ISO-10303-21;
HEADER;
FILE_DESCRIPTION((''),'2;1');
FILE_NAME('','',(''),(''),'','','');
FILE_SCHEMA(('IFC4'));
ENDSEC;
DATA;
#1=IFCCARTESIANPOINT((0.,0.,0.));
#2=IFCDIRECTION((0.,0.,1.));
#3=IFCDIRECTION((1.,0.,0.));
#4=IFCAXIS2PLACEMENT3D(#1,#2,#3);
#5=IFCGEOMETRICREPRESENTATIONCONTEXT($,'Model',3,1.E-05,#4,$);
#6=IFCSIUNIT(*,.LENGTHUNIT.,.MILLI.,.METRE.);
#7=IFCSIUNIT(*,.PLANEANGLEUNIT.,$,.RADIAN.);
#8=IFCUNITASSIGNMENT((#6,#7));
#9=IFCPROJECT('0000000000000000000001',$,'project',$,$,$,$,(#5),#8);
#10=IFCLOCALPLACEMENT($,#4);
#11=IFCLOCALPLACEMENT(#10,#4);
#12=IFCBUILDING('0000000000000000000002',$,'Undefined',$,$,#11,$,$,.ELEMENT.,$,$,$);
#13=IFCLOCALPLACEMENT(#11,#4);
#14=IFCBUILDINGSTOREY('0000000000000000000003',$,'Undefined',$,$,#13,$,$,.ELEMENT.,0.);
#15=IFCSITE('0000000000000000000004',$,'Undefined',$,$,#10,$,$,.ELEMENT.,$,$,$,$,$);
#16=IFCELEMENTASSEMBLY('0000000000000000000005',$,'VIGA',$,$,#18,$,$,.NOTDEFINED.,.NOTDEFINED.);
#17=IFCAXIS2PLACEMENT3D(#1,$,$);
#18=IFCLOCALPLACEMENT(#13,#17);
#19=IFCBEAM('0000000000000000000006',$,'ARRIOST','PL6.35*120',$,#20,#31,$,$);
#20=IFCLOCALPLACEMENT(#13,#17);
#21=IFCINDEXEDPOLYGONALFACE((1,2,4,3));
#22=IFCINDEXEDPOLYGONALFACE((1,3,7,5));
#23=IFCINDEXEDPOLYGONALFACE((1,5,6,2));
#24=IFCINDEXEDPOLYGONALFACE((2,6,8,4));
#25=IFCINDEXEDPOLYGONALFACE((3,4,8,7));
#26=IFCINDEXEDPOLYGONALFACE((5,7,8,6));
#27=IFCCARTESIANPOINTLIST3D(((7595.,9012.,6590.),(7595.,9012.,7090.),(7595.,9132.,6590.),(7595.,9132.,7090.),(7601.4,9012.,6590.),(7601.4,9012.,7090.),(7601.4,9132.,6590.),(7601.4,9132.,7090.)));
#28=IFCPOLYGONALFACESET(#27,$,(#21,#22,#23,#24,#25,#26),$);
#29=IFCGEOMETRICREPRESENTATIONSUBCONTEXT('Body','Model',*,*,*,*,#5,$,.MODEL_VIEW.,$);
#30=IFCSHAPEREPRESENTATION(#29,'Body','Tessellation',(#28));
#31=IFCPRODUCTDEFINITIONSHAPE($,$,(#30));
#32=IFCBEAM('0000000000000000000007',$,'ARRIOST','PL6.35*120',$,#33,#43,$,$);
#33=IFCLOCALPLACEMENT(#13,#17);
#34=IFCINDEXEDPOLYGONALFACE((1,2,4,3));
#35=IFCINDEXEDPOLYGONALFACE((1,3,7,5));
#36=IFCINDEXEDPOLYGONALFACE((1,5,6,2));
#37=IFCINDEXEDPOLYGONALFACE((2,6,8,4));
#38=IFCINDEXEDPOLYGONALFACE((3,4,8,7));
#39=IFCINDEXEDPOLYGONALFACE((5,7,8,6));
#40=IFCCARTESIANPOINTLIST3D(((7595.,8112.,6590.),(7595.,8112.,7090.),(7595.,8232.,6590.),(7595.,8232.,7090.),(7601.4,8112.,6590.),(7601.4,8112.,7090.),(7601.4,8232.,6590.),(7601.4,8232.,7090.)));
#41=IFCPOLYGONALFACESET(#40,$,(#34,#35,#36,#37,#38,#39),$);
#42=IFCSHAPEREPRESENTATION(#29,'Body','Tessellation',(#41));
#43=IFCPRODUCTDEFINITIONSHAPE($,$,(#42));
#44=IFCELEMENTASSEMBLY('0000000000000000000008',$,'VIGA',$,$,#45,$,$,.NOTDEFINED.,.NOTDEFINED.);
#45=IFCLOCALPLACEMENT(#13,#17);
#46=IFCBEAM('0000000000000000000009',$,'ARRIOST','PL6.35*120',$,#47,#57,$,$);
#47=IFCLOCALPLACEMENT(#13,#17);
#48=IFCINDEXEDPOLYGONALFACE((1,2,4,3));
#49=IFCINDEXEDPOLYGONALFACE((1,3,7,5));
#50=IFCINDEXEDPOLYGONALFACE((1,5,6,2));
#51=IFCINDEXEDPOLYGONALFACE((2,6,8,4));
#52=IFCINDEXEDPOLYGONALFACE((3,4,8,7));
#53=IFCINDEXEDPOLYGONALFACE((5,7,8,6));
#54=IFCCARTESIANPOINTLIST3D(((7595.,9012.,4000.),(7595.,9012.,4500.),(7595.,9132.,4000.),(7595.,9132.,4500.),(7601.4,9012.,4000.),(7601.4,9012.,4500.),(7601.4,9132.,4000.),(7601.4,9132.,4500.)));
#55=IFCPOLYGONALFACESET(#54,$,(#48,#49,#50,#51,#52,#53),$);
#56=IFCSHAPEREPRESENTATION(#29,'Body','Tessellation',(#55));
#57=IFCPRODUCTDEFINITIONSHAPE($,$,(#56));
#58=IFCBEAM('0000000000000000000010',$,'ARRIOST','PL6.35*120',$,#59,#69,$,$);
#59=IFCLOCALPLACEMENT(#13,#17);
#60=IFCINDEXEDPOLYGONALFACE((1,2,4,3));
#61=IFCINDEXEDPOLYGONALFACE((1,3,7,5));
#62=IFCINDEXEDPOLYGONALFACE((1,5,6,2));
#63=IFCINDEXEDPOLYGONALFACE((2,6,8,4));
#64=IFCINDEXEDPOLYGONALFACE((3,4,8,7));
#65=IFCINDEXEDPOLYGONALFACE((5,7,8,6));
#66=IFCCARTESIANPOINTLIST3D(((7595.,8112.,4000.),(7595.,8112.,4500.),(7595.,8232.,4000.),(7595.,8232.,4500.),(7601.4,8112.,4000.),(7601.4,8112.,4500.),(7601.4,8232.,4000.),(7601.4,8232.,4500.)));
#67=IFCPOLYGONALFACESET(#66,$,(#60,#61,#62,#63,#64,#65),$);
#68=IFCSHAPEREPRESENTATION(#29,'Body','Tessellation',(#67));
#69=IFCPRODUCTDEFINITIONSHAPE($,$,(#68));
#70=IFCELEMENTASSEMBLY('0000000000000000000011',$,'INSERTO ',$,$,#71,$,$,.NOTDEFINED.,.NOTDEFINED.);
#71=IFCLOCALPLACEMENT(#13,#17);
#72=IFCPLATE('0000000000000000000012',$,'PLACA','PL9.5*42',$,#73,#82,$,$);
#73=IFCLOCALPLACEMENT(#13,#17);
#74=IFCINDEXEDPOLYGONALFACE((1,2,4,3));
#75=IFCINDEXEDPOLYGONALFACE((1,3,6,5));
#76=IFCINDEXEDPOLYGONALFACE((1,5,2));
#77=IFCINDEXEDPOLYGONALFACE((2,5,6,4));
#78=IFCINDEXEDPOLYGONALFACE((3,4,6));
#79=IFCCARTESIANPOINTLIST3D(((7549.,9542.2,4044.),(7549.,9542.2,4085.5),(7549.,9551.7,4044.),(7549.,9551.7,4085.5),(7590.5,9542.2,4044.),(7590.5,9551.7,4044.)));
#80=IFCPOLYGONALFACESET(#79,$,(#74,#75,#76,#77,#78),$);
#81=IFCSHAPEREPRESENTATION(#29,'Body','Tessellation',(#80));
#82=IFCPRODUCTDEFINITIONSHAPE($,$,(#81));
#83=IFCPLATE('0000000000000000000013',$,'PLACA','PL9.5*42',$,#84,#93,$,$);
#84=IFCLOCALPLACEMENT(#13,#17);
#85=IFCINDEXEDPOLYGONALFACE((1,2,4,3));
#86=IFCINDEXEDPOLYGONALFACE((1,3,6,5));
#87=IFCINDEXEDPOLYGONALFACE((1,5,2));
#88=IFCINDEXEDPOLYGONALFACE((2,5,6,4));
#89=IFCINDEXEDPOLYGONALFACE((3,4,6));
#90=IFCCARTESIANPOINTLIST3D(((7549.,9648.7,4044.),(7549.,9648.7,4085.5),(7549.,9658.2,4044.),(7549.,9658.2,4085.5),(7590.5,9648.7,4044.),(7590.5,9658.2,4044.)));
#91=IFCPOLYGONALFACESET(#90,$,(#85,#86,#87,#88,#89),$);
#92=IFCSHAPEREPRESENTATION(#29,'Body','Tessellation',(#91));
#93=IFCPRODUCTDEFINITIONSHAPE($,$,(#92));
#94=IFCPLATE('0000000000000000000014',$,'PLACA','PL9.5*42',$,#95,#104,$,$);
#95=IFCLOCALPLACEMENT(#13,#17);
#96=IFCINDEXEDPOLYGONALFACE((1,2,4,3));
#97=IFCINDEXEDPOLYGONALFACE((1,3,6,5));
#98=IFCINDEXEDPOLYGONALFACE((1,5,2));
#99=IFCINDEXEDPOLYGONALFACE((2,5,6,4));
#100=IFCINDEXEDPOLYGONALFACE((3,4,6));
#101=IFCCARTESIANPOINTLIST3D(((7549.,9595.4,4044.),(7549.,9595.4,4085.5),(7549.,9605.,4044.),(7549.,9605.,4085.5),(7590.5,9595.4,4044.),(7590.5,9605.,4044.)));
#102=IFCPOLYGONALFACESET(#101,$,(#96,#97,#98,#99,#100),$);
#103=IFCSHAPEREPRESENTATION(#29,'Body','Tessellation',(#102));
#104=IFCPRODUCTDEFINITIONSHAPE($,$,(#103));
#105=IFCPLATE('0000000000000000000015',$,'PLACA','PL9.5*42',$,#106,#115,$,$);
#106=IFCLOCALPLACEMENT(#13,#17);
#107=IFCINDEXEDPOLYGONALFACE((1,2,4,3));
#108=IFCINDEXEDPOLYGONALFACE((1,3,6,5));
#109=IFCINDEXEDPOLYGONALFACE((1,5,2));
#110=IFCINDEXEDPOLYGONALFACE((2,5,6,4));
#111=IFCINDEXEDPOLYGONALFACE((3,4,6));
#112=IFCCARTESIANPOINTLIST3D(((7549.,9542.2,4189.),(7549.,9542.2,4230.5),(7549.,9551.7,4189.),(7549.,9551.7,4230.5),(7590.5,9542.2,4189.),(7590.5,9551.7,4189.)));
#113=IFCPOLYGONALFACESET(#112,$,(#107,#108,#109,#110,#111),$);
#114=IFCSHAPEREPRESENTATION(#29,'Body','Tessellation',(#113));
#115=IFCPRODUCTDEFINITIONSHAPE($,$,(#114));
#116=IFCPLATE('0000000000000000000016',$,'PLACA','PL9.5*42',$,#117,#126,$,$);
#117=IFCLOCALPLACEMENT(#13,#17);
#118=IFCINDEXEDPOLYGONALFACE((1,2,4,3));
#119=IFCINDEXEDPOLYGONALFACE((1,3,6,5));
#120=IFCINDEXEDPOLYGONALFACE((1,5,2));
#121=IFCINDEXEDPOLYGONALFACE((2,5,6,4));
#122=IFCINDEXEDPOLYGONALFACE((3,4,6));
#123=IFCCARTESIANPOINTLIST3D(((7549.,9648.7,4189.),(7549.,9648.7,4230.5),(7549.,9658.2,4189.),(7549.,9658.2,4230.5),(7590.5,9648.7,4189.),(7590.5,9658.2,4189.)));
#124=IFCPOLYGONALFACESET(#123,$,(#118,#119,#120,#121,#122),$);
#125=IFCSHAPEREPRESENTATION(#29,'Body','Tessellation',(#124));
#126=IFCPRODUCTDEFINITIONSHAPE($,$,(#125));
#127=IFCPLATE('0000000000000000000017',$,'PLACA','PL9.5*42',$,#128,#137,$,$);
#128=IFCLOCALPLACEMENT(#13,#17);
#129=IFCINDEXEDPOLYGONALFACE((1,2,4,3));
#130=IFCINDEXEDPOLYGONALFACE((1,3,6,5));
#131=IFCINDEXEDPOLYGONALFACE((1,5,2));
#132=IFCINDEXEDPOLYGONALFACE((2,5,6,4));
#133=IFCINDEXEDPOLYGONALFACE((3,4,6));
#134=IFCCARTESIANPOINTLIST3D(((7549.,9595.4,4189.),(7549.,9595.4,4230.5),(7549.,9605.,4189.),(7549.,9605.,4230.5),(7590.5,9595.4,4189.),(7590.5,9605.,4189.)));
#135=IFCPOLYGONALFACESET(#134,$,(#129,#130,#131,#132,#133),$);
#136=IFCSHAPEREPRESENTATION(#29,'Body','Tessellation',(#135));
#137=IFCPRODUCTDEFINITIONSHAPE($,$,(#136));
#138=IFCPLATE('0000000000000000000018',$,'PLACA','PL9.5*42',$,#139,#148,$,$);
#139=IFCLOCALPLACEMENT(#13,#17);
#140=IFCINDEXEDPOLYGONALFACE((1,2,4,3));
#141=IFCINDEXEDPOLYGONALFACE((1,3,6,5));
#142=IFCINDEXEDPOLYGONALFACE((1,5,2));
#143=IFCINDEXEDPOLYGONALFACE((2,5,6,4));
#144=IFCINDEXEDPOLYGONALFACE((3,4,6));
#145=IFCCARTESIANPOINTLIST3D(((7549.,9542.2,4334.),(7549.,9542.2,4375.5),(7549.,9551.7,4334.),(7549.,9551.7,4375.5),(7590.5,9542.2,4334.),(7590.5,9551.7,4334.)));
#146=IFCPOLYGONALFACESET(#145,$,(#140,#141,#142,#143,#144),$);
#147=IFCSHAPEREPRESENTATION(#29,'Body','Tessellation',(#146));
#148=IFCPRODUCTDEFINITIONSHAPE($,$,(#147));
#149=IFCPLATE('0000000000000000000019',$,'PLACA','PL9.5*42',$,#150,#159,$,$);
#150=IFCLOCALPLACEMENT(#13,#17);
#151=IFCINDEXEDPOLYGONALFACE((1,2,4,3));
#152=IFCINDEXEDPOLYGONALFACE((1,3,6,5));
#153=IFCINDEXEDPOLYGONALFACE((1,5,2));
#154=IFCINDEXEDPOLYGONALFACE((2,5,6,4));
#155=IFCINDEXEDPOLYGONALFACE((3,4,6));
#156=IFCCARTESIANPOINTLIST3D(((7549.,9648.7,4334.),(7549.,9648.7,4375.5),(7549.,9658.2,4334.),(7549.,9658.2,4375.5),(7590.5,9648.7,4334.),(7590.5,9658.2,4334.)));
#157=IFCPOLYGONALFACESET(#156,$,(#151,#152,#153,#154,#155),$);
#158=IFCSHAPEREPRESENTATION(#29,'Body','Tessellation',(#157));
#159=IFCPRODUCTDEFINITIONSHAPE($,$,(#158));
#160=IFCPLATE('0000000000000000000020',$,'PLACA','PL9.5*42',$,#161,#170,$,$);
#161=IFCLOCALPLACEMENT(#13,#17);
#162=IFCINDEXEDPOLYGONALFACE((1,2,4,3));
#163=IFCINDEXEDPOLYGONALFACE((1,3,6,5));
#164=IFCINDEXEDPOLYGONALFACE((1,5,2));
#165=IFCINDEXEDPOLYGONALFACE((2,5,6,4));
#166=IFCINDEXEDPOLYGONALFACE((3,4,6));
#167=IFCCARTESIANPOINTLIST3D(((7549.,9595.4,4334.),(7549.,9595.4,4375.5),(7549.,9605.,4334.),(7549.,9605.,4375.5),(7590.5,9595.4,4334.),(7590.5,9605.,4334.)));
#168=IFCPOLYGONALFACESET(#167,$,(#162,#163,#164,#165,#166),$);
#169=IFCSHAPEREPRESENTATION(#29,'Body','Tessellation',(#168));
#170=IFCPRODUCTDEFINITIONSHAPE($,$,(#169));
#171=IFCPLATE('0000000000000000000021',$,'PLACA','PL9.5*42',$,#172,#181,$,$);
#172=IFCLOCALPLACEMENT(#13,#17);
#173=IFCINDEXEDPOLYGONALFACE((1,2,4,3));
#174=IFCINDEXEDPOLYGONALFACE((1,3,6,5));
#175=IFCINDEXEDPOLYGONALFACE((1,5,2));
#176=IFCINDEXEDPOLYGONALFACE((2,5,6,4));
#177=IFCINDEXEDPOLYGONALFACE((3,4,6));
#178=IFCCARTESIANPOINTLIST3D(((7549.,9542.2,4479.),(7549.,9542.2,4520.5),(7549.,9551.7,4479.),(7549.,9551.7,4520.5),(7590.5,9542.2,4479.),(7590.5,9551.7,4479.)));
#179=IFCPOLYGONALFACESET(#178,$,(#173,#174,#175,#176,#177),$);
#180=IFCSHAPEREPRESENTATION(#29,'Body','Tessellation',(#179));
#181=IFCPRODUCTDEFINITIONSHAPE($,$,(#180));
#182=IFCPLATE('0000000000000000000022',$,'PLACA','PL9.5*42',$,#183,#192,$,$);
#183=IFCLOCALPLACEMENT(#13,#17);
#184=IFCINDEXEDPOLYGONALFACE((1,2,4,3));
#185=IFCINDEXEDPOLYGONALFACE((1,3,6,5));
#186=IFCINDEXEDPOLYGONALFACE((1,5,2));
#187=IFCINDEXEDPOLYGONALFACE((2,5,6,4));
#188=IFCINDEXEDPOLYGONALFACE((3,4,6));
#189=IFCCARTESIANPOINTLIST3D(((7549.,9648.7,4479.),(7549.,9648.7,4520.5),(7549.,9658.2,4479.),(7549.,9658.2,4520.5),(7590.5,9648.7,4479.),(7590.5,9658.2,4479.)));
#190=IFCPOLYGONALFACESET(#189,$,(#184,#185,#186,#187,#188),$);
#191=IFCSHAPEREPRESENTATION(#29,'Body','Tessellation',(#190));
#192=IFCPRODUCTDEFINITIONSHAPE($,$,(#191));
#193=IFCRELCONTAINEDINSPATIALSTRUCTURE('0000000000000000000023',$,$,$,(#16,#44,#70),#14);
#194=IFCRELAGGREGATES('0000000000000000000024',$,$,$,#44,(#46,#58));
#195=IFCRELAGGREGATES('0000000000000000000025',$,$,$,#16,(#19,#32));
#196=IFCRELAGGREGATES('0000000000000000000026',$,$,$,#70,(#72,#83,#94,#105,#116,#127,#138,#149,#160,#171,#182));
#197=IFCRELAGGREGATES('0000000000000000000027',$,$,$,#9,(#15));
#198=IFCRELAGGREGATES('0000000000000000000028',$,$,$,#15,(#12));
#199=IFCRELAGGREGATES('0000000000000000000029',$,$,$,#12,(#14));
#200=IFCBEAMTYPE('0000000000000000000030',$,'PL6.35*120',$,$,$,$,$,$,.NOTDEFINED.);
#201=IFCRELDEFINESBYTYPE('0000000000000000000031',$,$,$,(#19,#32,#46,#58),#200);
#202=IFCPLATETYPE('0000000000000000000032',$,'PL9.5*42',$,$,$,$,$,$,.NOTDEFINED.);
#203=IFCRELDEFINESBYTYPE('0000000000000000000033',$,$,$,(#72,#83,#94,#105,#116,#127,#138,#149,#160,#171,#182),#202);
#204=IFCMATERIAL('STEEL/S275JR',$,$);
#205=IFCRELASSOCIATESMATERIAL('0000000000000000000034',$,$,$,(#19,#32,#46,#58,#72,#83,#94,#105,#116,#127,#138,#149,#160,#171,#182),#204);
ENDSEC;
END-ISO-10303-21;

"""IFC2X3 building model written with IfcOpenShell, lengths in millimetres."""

from ifc_helpers import new_model, si_unit, frame, origin_with_axes, origin_2d_with_axis, place, context, subcontext, project, spatial, polyline, rectangle, outline, extrude, material, type_object, element, aggregate, save


model = new_model("IFC2X3")

# Units and contexts
model_context = context("Model", 3, precision=1e-05, world=origin_with_axes())
body_context = subcontext(model_context, "Body", "Model", "MODEL_VIEW")
ifc_project = project(units=[si_unit("LENGTHUNIT", "METRE", prefix="MILLI"), si_unit("PLANEANGLEUNIT", "RADIAN")], contexts=[model_context])

# Site, building, storey
site_placement = place(None, origin_with_axes())
site = spatial("IfcSite", under=ifc_project, at=site_placement, Name="Undefined", CompositionType="ELEMENT")
building_placement = place(site_placement, origin_with_axes())
building = spatial("IfcBuilding", under=site, at=building_placement, Name="Undefined", CompositionType="ELEMENT")
storey_placement = place(building_placement, origin_with_axes())
storey = spatial("IfcBuildingStorey", under=building, at=storey_placement, Name="Undefined", CompositionType="ELEMENT", Elevation=0.0)

# Element assemblies, beams
assembly_1_placement = place(storey_placement, origin_with_axes())
assembly_1 = element("IfcElementAssembly", 1, at=assembly_1_placement, inside=storey, Name="VIGA", AssemblyPlace="NOTDEFINED", PredefinedType="NOTDEFINED")
ifc_material = material(Name="STEEL/S275JR")
beam_type = type_object("IfcBeamType", Name="PL6.35*120", PredefinedType="NOTDEFINED")
beam_1_placement = place(assembly_1_placement, frame((7598.2, 9072.0, 6590.0), z_axis=(0.0, 1.0, 0.0), x_axis=(0.0, 0.0, 1.0)))
beam_1 = element("IfcBeam", 2, at=beam_1_placement, type_object=beam_type, material=ifc_material, Name="ARRIOST", Description="PL6.35*120", context=body_context, shape_type="SweptSolid", body=[
    extrude(rectangle(XDim=6.3, YDim=120.0, at=origin_2d_with_axis()), frame((500.0, 0.0, 0.0), z_axis=(-1.0, 0.0, 0.0), x_axis=(0.0, -1.0, 0.0)), (0.0, 0.0, 1.0), 500.0),
])
beam_2_placement = place(assembly_1_placement, frame((7598.2, 8172.0, 6590.0), z_axis=(0.0, 1.0, 0.0), x_axis=(0.0, 0.0, 1.0)))
beam_2 = element("IfcBeam", 3, at=beam_2_placement, type_object=beam_type, material=ifc_material, Name="ARRIOST", Description="PL6.35*120", context=body_context, shape_type="SweptSolid", body=[
    extrude(rectangle(XDim=6.3, YDim=120.0, at=origin_2d_with_axis()), frame((500.0, 0.0, 0.0), z_axis=(-1.0, 0.0, 0.0), x_axis=(0.0, -1.0, 0.0)), (0.0, 0.0, 1.0), 500.0),
])
assembly_2_placement = place(storey_placement, origin_with_axes())
assembly_2 = element("IfcElementAssembly", 4, at=assembly_2_placement, inside=storey, Name="VIGA", AssemblyPlace="NOTDEFINED", PredefinedType="NOTDEFINED")
beam_3_placement = place(assembly_2_placement, frame((7598.2, 9072.0, 4000.0), z_axis=(0.0, 1.0, 0.0), x_axis=(0.0, 0.0, 1.0)))
beam_3 = element("IfcBeam", 5, at=beam_3_placement, type_object=beam_type, material=ifc_material, Name="ARRIOST", Description="PL6.35*120", context=body_context, shape_type="SweptSolid", body=[
    extrude(rectangle(XDim=6.3, YDim=120.0, at=origin_2d_with_axis()), frame((500.0, 0.0, 0.0), z_axis=(-1.0, 0.0, 0.0), x_axis=(0.0, -1.0, 0.0)), (0.0, 0.0, 1.0), 500.0),
])
beam_4_placement = place(assembly_2_placement, frame((7598.2, 8172.0, 4000.0), z_axis=(0.0, 1.0, 0.0), x_axis=(0.0, 0.0, 1.0)))
beam_4 = element("IfcBeam", 6, at=beam_4_placement, type_object=beam_type, material=ifc_material, Name="ARRIOST", Description="PL6.35*120", context=body_context, shape_type="SweptSolid", body=[
    extrude(rectangle(XDim=6.3, YDim=120.0, at=origin_2d_with_axis()), frame((500.0, 0.0, 0.0), z_axis=(-1.0, 0.0, 0.0), x_axis=(0.0, -1.0, 0.0)), (0.0, 0.0, 1.0), 500.0),
])
aggregate(assembly_2, [beam_3, beam_4])

# Element assembly, plates
assembly_3_placement = place(storey_placement, origin_with_axes())
assembly_3 = element("IfcElementAssembly", 7, at=assembly_3_placement, inside=storey, Name="INSERTO ", AssemblyPlace="NOTDEFINED", PredefinedType="NOTDEFINED")
plate_type_1 = type_object("IfcPlateType", Name="PL9.5*42", PredefinedType="NOTDEFINED")
plate_1_placement = place(assembly_3_placement, frame((7549.0, 9547.0, 4044.0), z_axis=(0.0, 1.0, 0.0), x_axis=(0.0, 0.0, 1.0)))
plate_1 = element("IfcPlate", 8, at=plate_1_placement, type_object=plate_type_1, material=ifc_material, Name="PLACA", Description="PL9.5*42", context=body_context, shape_type="SweptSolid", body=[
    extrude(outline(polyline([(0.0, 0.0), (41.5, 0.0), (0.0, 41.5), (0.0, 0.0)])), frame((0.0, 0.0, -4.7), z_axis=(0.0, 0.0, 1.0), x_axis=(1.0, 0.0, 0.0)), (0.0, 0.0, 1.0), 9.5),
])
plate_2_placement = place(assembly_3_placement, frame((7549.0, 9653.5, 4044.0), z_axis=(0.0, 1.0, 0.0), x_axis=(0.0, 0.0, 1.0)))
plate_2 = element("IfcPlate", 9, at=plate_2_placement, type_object=plate_type_1, material=ifc_material, Name="PLACA", Description="PL9.5*42", context=body_context, shape_type="SweptSolid", body=[
    extrude(outline(polyline([(0.0, 0.0), (41.5, 0.0), (0.0, 41.5), (0.0, 0.0)])), frame((0.0, 0.0, -4.7), z_axis=(0.0, 0.0, 1.0), x_axis=(1.0, 0.0, 0.0)), (0.0, 0.0, 1.0), 9.5),
])
plate_3_placement = place(assembly_3_placement, frame((7549.0, 9600.2, 4044.0), z_axis=(0.0, 1.0, 0.0), x_axis=(0.0, 0.0, 1.0)))
plate_3 = element("IfcPlate", 10, at=plate_3_placement, type_object=plate_type_1, material=ifc_material, Name="PLACA", Description="PL9.5*42", context=body_context, shape_type="SweptSolid", body=[
    extrude(outline(polyline([(0.0, 0.0), (41.5, 0.0), (0.0, 41.5), (0.0, 0.0)])), frame((0.0, 0.0, -4.7), z_axis=(0.0, 0.0, 1.0), x_axis=(1.0, 0.0, 0.0)), (0.0, 0.0, 1.0), 9.5),
])
plate_4_placement = place(assembly_3_placement, frame((7549.0, 9547.0, 4189.0), z_axis=(0.0, 1.0, 0.0), x_axis=(0.0, 0.0, 1.0)))
plate_4 = element("IfcPlate", 11, at=plate_4_placement, type_object=plate_type_1, material=ifc_material, Name="PLACA", Description="PL9.5*42", context=body_context, shape_type="SweptSolid", body=[
    extrude(outline(polyline([(0.0, 0.0), (41.5, 0.0), (0.0, 41.5), (0.0, 0.0)])), frame((0.0, 0.0, -4.7), z_axis=(0.0, 0.0, 1.0), x_axis=(1.0, 0.0, 0.0)), (0.0, 0.0, 1.0), 9.5),
])
plate_5_placement = place(assembly_3_placement, frame((7549.0, 9653.5, 4189.0), z_axis=(0.0, 1.0, 0.0), x_axis=(0.0, 0.0, 1.0)))
plate_5 = element("IfcPlate", 12, at=plate_5_placement, type_object=plate_type_1, material=ifc_material, Name="PLACA", Description="PL9.5*42", context=body_context, shape_type="SweptSolid", body=[
    extrude(outline(polyline([(0.0, 0.0), (41.5, 0.0), (0.0, 41.5), (0.0, 0.0)])), frame((0.0, 0.0, -4.7), z_axis=(0.0, 0.0, 1.0), x_axis=(1.0, 0.0, 0.0)), (0.0, 0.0, 1.0), 9.5),
])
plate_6_placement = place(assembly_3_placement, frame((7549.0, 9600.2, 4189.0), z_axis=(0.0, 1.0, 0.0), x_axis=(0.0, 0.0, 1.0)))
plate_6 = element("IfcPlate", 13, at=plate_6_placement, type_object=plate_type_1, material=ifc_material, Name="PLACA", Description="PL9.5*42", context=body_context, shape_type="SweptSolid", body=[
    extrude(outline(polyline([(0.0, 0.0), (41.5, 0.0), (0.0, 41.5), (0.0, 0.0)])), frame((0.0, 0.0, -4.7), z_axis=(0.0, 0.0, 1.0), x_axis=(1.0, 0.0, 0.0)), (0.0, 0.0, 1.0), 9.5),
])
plate_7_placement = place(assembly_3_placement, frame((7549.0, 9547.0, 4334.0), z_axis=(0.0, 1.0, 0.0), x_axis=(0.0, 0.0, 1.0)))
plate_7 = element("IfcPlate", 14, at=plate_7_placement, type_object=plate_type_1, material=ifc_material, Name="PLACA", Description="PL9.5*42", context=body_context, shape_type="SweptSolid", body=[
    extrude(outline(polyline([(0.0, 0.0), (41.5, 0.0), (0.0, 41.5), (0.0, 0.0)])), frame((0.0, 0.0, -4.7), z_axis=(0.0, 0.0, 1.0), x_axis=(1.0, 0.0, 0.0)), (0.0, 0.0, 1.0), 9.5),
])
plate_8_placement = place(assembly_3_placement, frame((7549.0, 9653.5, 4334.0), z_axis=(0.0, 1.0, 0.0), x_axis=(0.0, 0.0, 1.0)))
plate_8 = element("IfcPlate", 15, at=plate_8_placement, type_object=plate_type_1, material=ifc_material, Name="PLACA", Description="PL9.5*42", context=body_context, shape_type="SweptSolid", body=[
    extrude(outline(polyline([(0.0, 0.0), (41.5, 0.0), (0.0, 41.5), (0.0, 0.0)])), frame((0.0, 0.0, -4.7), z_axis=(0.0, 0.0, 1.0), x_axis=(1.0, 0.0, 0.0)), (0.0, 0.0, 1.0), 9.5),
])
plate_9_placement = place(assembly_3_placement, frame((7549.0, 9600.2, 4334.0), z_axis=(0.0, 1.0, 0.0), x_axis=(0.0, 0.0, 1.0)))
plate_9 = element("IfcPlate", 16, at=plate_9_placement, type_object=plate_type_1, material=ifc_material, Name="PLACA", Description="PL9.5*42", context=body_context, shape_type="SweptSolid", body=[
    extrude(outline(polyline([(0.0, 0.0), (41.5, 0.0), (0.0, 41.5), (0.0, 0.0)])), frame((0.0, 0.0, -4.7), z_axis=(0.0, 0.0, 1.0), x_axis=(1.0, 0.0, 0.0)), (0.0, 0.0, 1.0), 9.5),
])
plate_10_placement = place(assembly_3_placement, frame((7549.0, 9547.0, 4479.0), z_axis=(0.0, 1.0, 0.0), x_axis=(0.0, 0.0, 1.0)))
plate_10 = element("IfcPlate", 17, at=plate_10_placement, type_object=plate_type_1, material=ifc_material, Name="PLACA", Description="PL9.5*42", context=body_context, shape_type="SweptSolid", body=[
    extrude(outline(polyline([(0.0, 0.0), (41.5, 0.0), (0.0, 41.5), (0.0, 0.0)])), frame((0.0, 0.0, -4.7), z_axis=(0.0, 0.0, 1.0), x_axis=(1.0, 0.0, 0.0)), (0.0, 0.0, 1.0), 9.5),
])
plate_11_placement = place(assembly_3_placement, frame((7549.0, 9653.4, 4479.0), z_axis=(0.0, 1.0, 0.0), x_axis=(0.0, 0.0, 1.0)))
plate_11 = element("IfcPlate", 18, at=plate_11_placement, type_object=plate_type_1, material=ifc_material, Name="PLACA", Description="PL9.5*42", context=body_context, shape_type="SweptSolid", body=[
    extrude(outline(polyline([(0.0, 0.0), (41.5, 0.0), (0.0, 41.5), (0.0, 0.0)])), frame((0.0, 0.0, -4.7), z_axis=(0.0, 0.0, 1.0), x_axis=(1.0, 0.0, 0.0)), (0.0, 0.0, 1.0), 9.5),
])

aggregate(assembly_1, [beam_1, beam_2])
aggregate(assembly_3, [plate_1, plate_2, plate_3, plate_4, plate_5, plate_6, plate_7, plate_8, plate_9, plate_10, plate_11])

save(model, "model.ifc")
